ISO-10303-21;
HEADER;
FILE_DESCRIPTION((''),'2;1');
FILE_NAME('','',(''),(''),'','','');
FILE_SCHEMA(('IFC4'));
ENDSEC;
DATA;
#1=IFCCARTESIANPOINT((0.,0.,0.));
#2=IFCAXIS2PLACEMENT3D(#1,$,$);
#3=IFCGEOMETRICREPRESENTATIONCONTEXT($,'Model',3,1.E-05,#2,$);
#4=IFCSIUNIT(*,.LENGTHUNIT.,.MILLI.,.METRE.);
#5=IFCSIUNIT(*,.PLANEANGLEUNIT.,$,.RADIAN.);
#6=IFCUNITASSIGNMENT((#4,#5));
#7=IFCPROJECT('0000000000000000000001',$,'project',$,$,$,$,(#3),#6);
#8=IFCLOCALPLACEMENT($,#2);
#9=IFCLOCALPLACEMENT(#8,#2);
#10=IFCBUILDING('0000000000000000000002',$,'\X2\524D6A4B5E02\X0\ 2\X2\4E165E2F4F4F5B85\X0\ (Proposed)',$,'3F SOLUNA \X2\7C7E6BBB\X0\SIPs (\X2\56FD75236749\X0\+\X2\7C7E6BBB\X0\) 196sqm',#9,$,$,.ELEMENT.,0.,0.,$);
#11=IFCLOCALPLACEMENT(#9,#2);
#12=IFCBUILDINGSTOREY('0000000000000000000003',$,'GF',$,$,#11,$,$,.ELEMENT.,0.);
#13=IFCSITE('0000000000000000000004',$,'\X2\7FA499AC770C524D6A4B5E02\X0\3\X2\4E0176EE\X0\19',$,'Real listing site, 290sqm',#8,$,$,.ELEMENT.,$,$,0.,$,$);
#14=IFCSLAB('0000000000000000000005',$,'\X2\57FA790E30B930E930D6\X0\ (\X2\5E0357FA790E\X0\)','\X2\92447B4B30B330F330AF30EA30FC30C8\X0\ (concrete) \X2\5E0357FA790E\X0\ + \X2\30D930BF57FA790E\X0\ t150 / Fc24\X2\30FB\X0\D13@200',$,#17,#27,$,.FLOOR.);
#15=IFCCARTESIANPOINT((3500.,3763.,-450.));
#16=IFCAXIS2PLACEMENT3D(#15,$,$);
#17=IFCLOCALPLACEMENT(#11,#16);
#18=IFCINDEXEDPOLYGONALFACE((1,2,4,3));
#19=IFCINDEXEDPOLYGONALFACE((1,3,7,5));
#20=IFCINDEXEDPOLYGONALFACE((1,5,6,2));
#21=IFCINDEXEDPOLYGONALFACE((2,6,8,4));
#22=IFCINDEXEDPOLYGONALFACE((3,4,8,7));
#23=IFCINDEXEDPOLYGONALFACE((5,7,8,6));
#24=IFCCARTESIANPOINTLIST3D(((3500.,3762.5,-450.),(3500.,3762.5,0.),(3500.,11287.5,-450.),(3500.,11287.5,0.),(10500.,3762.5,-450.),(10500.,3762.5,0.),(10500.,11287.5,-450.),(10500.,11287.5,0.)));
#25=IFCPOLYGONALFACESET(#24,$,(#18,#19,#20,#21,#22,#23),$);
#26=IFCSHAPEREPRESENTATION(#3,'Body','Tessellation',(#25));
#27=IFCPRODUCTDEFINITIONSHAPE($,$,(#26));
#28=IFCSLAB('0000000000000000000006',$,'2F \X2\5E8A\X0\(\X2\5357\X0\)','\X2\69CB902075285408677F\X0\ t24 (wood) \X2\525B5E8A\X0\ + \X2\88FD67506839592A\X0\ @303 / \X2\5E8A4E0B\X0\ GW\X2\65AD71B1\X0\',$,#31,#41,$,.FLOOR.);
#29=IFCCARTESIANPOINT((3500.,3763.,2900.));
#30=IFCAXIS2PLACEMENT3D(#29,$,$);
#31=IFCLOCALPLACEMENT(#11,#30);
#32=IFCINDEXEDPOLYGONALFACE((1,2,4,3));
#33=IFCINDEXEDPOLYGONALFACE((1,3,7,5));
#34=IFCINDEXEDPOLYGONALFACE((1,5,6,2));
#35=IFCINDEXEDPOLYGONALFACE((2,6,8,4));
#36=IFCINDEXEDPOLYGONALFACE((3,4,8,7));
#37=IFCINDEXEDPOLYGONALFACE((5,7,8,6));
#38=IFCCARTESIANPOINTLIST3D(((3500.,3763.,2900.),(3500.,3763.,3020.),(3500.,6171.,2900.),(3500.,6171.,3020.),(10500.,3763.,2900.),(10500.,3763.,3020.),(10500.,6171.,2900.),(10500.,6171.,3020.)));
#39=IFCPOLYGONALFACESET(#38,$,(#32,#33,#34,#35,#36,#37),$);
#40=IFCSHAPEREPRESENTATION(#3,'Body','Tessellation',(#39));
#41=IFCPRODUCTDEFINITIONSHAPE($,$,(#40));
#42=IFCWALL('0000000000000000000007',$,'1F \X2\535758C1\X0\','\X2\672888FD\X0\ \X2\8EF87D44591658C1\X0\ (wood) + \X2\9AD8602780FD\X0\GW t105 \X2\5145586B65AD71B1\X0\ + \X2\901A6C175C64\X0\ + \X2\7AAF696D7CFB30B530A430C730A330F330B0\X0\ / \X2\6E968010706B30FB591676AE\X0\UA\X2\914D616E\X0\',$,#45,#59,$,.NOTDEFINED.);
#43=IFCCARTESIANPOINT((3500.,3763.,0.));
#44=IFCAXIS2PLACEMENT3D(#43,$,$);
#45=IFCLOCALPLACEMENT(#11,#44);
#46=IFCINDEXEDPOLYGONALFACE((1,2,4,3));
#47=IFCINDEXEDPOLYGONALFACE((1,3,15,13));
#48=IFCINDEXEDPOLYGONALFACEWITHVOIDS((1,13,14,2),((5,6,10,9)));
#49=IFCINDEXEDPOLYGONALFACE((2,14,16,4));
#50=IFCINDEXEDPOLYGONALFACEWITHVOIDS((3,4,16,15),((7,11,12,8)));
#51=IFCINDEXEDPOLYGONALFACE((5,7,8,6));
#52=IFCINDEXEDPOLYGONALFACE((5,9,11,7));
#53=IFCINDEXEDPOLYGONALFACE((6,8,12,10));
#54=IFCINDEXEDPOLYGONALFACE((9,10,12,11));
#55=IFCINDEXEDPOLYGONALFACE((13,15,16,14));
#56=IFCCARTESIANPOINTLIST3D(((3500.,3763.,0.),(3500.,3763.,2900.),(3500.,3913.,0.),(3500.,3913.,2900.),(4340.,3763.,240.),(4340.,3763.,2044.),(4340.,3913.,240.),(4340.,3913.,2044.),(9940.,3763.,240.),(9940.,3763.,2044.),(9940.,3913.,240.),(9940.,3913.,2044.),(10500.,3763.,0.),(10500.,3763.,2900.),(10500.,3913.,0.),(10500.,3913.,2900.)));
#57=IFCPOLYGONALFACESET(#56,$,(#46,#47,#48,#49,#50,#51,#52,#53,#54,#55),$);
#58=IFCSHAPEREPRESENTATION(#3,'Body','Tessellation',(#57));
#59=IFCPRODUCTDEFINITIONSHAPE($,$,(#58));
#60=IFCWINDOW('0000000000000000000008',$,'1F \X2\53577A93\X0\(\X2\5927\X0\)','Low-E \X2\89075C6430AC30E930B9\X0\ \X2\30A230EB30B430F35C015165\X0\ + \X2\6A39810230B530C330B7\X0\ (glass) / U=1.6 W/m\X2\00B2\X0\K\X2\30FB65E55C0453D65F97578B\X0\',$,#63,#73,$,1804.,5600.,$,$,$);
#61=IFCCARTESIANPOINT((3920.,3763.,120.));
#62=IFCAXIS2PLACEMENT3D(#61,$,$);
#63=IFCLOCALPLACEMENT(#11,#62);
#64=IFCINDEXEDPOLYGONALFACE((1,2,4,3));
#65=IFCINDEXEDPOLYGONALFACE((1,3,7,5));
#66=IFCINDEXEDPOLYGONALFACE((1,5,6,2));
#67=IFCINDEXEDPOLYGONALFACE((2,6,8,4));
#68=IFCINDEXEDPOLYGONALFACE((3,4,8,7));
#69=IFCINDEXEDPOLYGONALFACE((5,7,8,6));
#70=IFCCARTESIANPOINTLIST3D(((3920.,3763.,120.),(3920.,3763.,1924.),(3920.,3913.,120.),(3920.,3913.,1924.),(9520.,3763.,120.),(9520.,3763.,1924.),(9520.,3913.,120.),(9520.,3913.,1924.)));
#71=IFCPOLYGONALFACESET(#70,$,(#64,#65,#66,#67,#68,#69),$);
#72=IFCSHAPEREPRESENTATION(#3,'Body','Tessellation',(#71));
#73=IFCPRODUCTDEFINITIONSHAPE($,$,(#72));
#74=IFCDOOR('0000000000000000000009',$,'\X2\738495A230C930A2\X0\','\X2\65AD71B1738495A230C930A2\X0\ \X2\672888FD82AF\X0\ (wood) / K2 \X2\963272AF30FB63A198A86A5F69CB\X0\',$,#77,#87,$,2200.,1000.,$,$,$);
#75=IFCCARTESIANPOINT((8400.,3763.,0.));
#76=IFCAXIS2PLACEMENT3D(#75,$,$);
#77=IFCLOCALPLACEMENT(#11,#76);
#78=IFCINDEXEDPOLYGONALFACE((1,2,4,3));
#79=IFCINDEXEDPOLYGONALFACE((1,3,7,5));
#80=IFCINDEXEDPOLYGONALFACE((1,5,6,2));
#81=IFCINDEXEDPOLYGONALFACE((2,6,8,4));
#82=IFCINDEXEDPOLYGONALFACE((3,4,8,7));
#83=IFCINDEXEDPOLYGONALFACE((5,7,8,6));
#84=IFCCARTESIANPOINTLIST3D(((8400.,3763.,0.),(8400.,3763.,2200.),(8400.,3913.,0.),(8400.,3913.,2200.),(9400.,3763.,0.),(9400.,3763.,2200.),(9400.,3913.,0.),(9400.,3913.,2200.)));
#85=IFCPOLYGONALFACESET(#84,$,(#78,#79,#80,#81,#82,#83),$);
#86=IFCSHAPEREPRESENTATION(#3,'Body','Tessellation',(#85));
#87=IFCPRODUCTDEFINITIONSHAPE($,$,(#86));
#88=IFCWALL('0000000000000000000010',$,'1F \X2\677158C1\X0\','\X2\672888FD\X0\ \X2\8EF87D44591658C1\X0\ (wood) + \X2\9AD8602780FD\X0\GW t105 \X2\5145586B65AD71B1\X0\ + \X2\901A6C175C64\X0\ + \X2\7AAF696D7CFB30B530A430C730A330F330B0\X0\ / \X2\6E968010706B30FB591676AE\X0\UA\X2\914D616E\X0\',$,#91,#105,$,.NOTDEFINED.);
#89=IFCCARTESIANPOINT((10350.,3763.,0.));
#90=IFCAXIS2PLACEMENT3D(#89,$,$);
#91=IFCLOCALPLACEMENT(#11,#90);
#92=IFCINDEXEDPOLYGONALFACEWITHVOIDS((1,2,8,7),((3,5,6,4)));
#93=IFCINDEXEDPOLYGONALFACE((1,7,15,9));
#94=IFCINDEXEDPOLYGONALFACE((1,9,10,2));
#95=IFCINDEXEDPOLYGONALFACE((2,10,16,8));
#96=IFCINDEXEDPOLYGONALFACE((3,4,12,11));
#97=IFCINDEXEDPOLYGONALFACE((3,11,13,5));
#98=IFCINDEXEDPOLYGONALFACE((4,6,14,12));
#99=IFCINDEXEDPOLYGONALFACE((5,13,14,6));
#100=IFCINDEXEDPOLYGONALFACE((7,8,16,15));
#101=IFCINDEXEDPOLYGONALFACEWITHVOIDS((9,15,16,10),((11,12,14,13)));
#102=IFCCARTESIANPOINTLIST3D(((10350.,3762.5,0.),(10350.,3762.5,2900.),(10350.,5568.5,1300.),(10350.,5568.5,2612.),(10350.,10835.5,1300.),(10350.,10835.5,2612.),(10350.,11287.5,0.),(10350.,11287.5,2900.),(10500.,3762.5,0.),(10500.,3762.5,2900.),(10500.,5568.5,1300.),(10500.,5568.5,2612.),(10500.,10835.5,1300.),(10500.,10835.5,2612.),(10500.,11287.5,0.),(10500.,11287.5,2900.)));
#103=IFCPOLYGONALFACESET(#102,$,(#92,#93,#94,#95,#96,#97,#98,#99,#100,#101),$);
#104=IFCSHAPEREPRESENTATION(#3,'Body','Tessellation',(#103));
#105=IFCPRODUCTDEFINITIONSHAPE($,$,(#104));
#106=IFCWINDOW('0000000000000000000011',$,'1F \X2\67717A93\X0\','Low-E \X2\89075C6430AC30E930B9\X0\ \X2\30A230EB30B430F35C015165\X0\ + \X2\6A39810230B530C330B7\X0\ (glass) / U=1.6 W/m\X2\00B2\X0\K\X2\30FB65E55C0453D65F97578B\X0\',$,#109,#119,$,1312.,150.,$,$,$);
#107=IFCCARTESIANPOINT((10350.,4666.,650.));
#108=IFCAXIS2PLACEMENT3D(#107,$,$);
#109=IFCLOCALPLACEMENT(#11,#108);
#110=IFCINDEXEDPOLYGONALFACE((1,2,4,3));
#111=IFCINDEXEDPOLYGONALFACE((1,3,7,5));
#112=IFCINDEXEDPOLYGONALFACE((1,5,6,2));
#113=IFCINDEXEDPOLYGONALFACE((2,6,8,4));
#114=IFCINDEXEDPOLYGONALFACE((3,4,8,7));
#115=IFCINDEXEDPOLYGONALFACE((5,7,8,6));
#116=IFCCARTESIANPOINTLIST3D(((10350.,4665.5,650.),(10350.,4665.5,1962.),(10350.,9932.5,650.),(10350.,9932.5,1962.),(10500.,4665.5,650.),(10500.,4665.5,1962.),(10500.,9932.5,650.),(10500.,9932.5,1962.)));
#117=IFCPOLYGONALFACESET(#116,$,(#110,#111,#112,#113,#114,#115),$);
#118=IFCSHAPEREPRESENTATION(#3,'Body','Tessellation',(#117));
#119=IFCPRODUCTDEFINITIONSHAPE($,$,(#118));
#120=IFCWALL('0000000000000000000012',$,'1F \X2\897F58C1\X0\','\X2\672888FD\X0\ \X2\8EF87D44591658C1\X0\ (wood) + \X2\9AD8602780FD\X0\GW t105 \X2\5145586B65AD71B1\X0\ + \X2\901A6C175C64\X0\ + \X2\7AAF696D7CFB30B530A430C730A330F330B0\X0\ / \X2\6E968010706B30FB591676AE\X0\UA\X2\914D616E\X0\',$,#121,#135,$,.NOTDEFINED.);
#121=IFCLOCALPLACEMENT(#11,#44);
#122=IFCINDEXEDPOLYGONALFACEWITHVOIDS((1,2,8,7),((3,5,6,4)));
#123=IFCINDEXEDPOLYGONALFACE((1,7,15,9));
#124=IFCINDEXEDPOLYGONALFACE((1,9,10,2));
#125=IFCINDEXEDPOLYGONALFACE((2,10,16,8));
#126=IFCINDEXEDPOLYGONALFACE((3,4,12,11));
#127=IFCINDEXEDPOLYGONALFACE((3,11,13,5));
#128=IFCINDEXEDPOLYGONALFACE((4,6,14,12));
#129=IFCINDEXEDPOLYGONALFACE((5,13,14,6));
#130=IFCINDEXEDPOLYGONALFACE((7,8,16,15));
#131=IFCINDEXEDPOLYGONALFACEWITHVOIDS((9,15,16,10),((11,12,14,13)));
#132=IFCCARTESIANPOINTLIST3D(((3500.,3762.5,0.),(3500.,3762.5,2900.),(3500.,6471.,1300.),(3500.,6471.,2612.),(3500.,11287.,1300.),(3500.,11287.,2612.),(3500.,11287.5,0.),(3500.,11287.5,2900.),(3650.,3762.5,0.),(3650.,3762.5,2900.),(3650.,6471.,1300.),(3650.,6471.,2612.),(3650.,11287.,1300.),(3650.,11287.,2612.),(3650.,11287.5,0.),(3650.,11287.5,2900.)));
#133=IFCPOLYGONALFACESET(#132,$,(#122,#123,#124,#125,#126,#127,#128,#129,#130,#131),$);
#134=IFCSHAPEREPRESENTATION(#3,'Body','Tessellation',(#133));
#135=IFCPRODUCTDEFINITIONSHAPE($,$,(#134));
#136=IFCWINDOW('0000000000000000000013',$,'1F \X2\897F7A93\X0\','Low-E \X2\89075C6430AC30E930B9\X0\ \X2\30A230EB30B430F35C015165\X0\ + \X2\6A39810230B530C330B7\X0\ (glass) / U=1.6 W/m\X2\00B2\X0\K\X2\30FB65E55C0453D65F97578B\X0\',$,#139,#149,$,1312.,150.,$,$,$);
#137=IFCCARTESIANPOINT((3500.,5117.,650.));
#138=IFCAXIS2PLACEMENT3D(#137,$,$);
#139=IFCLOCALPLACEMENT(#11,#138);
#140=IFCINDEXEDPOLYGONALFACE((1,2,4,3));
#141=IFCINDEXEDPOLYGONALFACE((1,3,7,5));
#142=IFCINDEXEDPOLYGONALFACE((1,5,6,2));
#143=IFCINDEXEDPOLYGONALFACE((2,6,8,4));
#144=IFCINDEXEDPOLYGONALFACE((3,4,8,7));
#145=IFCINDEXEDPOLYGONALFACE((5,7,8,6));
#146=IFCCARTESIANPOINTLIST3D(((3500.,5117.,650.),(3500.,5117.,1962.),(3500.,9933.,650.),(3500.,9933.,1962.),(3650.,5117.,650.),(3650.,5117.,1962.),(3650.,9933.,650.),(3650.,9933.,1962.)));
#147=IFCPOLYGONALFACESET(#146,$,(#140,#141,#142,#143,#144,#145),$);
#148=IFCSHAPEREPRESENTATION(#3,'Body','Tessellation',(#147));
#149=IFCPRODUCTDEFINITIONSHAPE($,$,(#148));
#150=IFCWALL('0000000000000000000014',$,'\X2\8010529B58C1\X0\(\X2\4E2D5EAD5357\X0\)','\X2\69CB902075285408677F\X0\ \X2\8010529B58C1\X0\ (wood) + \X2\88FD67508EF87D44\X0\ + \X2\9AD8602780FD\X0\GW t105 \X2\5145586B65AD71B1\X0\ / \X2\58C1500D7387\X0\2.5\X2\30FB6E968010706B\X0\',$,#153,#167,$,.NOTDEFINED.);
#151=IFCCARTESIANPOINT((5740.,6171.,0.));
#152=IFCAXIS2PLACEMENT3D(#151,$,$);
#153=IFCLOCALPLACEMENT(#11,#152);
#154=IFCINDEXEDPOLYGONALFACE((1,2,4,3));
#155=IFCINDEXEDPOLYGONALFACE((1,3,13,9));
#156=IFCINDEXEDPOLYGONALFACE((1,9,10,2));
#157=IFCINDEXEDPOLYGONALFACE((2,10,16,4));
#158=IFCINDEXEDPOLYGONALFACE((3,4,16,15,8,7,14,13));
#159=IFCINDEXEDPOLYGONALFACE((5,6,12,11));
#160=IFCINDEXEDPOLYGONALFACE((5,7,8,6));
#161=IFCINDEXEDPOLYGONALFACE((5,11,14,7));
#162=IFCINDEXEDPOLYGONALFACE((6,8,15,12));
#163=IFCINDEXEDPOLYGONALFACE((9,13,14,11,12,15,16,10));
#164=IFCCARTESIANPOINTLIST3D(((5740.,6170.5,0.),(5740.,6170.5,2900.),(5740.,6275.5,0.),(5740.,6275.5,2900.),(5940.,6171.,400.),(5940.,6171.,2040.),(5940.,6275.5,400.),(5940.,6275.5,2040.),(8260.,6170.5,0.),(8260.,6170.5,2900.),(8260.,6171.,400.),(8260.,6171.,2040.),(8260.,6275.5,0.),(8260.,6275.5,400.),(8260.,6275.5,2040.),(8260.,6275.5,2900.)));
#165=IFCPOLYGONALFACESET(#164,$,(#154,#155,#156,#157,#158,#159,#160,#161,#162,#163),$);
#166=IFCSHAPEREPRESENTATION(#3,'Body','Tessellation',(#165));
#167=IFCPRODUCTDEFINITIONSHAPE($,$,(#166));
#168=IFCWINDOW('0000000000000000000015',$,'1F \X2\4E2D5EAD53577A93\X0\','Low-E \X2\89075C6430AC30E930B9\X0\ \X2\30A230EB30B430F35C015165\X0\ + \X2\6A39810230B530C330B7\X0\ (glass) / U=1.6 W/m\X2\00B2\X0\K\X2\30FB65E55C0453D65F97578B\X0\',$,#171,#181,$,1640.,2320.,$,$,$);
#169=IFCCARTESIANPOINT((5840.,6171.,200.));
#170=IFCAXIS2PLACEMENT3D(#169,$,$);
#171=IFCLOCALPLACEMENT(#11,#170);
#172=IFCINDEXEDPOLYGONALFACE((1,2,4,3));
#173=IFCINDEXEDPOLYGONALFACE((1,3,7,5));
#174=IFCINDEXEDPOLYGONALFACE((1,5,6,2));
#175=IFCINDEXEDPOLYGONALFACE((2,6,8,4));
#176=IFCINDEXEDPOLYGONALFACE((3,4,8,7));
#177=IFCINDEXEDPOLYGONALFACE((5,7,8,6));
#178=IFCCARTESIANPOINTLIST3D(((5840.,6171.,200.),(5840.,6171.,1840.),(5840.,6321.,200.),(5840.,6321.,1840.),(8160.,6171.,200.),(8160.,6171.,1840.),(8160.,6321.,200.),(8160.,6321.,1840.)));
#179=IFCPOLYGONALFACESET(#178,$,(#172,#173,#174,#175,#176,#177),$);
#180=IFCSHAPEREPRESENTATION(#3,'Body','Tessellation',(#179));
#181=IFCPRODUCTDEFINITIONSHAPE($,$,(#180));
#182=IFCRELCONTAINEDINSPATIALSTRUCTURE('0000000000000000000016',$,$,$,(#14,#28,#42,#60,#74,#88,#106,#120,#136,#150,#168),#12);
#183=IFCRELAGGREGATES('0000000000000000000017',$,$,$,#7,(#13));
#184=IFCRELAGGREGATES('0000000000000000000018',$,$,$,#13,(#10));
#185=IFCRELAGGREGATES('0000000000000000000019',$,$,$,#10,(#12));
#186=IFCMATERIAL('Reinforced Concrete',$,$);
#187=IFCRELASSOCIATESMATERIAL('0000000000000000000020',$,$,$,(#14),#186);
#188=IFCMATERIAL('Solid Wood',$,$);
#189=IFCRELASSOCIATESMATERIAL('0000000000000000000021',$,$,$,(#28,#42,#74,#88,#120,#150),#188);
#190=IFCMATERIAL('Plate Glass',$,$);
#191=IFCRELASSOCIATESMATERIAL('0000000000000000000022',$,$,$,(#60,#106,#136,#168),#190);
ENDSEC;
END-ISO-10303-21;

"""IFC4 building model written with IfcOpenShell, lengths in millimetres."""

from ifc_helpers import new_model, si_unit, frame, frame_2d, origin, place, context, project, spatial, rectangle, extrude, material, element, fill, save


model = new_model("IFC4")

# Units and contexts
model_context = context("Model", 3, precision=1e-05, world=origin())
ifc_project = project(units=[si_unit("LENGTHUNIT", "METRE", prefix="MILLI"), si_unit("PLANEANGLEUNIT", "RADIAN")], contexts=[model_context])

# Site, building, storey
site_placement = place(None, origin())
site = spatial("IfcSite", under=ifc_project, at=site_placement, Name="群馬県前橋市3丁目19", ObjectType="Real listing site, 290sqm", CompositionType="ELEMENT", RefElevation=0.0)
building_placement = place(site_placement, origin())
building = spatial("IfcBuilding", under=site, at=building_placement, Name="前橋市 2世帯住宅 (Proposed)", ObjectType="3F SOLUNA 籾殻SIPs (国産杉+籾殻) 196sqm", CompositionType="ELEMENT", ElevationOfRefHeight=0.0, ElevationOfTerrain=0.0)
storey_placement = place(building_placement, origin())
storey = spatial("IfcBuildingStorey", under=building, at=storey_placement, Name="GF", CompositionType="ELEMENT", Elevation=0.0)

# Slabs
ifc_material_1 = material(Name="Reinforced Concrete")
slab_1_placement = place(storey_placement, frame((3500.0, 3763.0, -450.0)))
element("IfcSlab", 1, at=slab_1_placement, inside=storey, material=ifc_material_1, Name="基礎スラブ (布基礎)", Description="鉄筋コンクリート (concrete) 布基礎 + ベタ基礎 t150 / Fc24・D13@200", PredefinedType="FLOOR", context=model_context, shape_type="SweptSolid", body=[
    extrude(rectangle(XDim=7000.0, YDim=7525.0, at=frame_2d((3500.0, 3762.0))), frame((3500.0, 3763.0, -450.0)), (0.0, 0.0, 1.0), 450.0),
])
ifc_material_2 = material(Name="Solid Wood")
slab_2_placement = place(storey_placement, frame((3500.0, 3763.0, 2900.0)))
element("IfcSlab", 2, at=slab_2_placement, inside=storey, material=ifc_material_2, Name="2F 床(南)", Description="構造用合板 t24 (wood) 剛床 + 製材根太 @303 / 床下 GW断熱", PredefinedType="FLOOR", context=model_context, shape_type="SweptSolid", body=[
    extrude(rectangle(XDim=7000.0, YDim=2408.0, at=frame_2d((3500.0, 1204.0))), frame((3500.0, 3763.0, 2900.0)), (0.0, 0.0, 1.0), 120.0),
])

# Wall, openings, window, door
wall_1_placement = place(storey_placement, frame((3500.0, 3763.0, 0.0)))
wall_1 = element("IfcWall", 3, at=wall_1_placement, inside=storey, material=ifc_material_2, Name="1F 南壁", Description="木製 軸組外壁 (wood) + 高性能GW t105 充填断熱 + 通気層 + 窯業系サイディング / 準耐火・外皮UA配慮", PredefinedType="NOTDEFINED", context=model_context, shape_type="SweptSolid", body=[
    extrude(rectangle(XDim=7000.0, YDim=150.0, at=frame_2d((3500.0, 75.0))), frame((3500.0, 3763.0, 0.0)), (0.0, 0.0, 1.0), 2900.0),
])
opening_1_placement = place(storey_placement, frame((3920.0, 3763.0, 120.0)))
opening_1 = element("IfcOpeningElement", 4, at=opening_1_placement, cuts=wall_1, PredefinedType="NOTDEFINED", context=model_context, shape_type="SweptSolid", body=[
    extrude(rectangle(XDim=5600.0, YDim=150.0, at=frame_2d((2800.0, 75.0))), frame((3920.0, 3763.0, 120.0)), (0.0, 0.0, 1.0), 1804.0),
])
opening_2_placement = place(storey_placement, frame((8400.0, 3763.0, 0.0)))
opening_2 = element("IfcOpeningElement", 5, at=opening_2_placement, cuts=wall_1, PredefinedType="NOTDEFINED", context=model_context, shape_type="SweptSolid", body=[
    extrude(rectangle(XDim=1000.0, YDim=150.0, at=frame_2d((500.0, 75.0))), frame((8400.0, 3763.0, 0.0)), (0.0, 0.0, 1.0), 2200.0),
])
ifc_material_3 = material(Name="Plate Glass")
window_1_placement = place(storey_placement, frame((3920.0, 3763.0, 120.0)))
window_1 = element("IfcWindow", 6, at=window_1_placement, inside=storey, material=ifc_material_3, Name="1F 南窓(大)", Description="Low-E 複層ガラス アルゴン封入 + 樹脂サッシ (glass) / U=1.6 W/m²K・日射取得型", OverallHeight=1804.0, OverallWidth=5600.0, context=model_context, shape_type="SweptSolid", body=[
    extrude(rectangle(XDim=5600.0, YDim=150.0, at=frame_2d((2800.0, 75.0))), frame((3920.0, 3763.0, 120.0)), (0.0, 0.0, 1.0), 1804.0),
])
fill(opening_1, window_1)
door_placement = place(storey_placement, frame((8400.0, 3763.0, 0.0)))
door = element("IfcDoor", 7, at=door_placement, inside=storey, material=ifc_material_2, Name="玄関ドア", Description="断熱玄関ドア 木製芯 (wood) / K2 防犯・採風機構", OverallHeight=2200.0, OverallWidth=1000.0, context=model_context, shape_type="SweptSolid", body=[
    extrude(rectangle(XDim=1000.0, YDim=150.0, at=frame_2d((500.0, 75.0))), frame((8400.0, 3763.0, 0.0)), (0.0, 0.0, 1.0), 2200.0),
])
fill(opening_2, door)

# Walls, openings, windows
wall_2_placement = place(storey_placement, frame((10350.0, 3763.0, 0.0)))
wall_2 = element("IfcWall", 8, at=wall_2_placement, inside=storey, material=ifc_material_2, Name="1F 東壁", Description="木製 軸組外壁 (wood) + 高性能GW t105 充填断熱 + 通気層 + 窯業系サイディング / 準耐火・外皮UA配慮", PredefinedType="NOTDEFINED", context=model_context, shape_type="SweptSolid", body=[
    extrude(rectangle(XDim=150.0, YDim=7525.0, at=frame_2d((75.0, 3762.0))), frame((10350.0, 3763.0, 0.0)), (0.0, 0.0, 1.0), 2900.0),
])
opening_3_placement = place(storey_placement, frame((10350.0, 4666.0, 650.0)))
opening_3 = element("IfcOpeningElement", 9, at=opening_3_placement, cuts=wall_2, PredefinedType="NOTDEFINED", context=model_context, shape_type="SweptSolid", body=[
    extrude(rectangle(XDim=150.0, YDim=5267.0, at=frame_2d((75.0, 2633.0))), frame((10350.0, 4666.0, 650.0)), (0.0, 0.0, 1.0), 1312.0),
])
window_2_placement = place(storey_placement, frame((10350.0, 4666.0, 650.0)))
window_2 = element("IfcWindow", 10, at=window_2_placement, inside=storey, material=ifc_material_3, Name="1F 東窓", Description="Low-E 複層ガラス アルゴン封入 + 樹脂サッシ (glass) / U=1.6 W/m²K・日射取得型", OverallHeight=1312.0, OverallWidth=150.0, context=model_context, shape_type="SweptSolid", body=[
    extrude(rectangle(XDim=150.0, YDim=5267.0, at=frame_2d((75.0, 2633.0))), frame((10350.0, 4666.0, 650.0)), (0.0, 0.0, 1.0), 1312.0),
])
fill(opening_3, window_2)
wall_3_placement = place(storey_placement, frame((3500.0, 3763.0, 0.0)))
wall_3 = element("IfcWall", 11, at=wall_3_placement, inside=storey, material=ifc_material_2, Name="1F 西壁", Description="木製 軸組外壁 (wood) + 高性能GW t105 充填断熱 + 通気層 + 窯業系サイディング / 準耐火・外皮UA配慮", PredefinedType="NOTDEFINED", context=model_context, shape_type="SweptSolid", body=[
    extrude(rectangle(XDim=150.0, YDim=7525.0, at=frame_2d((75.0, 3762.0))), frame((3500.0, 3763.0, 0.0)), (0.0, 0.0, 1.0), 2900.0),
])
opening_4_placement = place(storey_placement, frame((3500.0, 5117.0, 650.0)))
opening_4 = element("IfcOpeningElement", 12, at=opening_4_placement, cuts=wall_3, PredefinedType="NOTDEFINED", context=model_context, shape_type="SweptSolid", body=[
    extrude(rectangle(XDim=150.0, YDim=4816.0, at=frame_2d((75.0, 2408.0))), frame((3500.0, 5117.0, 650.0)), (0.0, 0.0, 1.0), 1312.0),
])
window_3_placement = place(storey_placement, frame((3500.0, 5117.0, 650.0)))
window_3 = element("IfcWindow", 13, at=window_3_placement, inside=storey, material=ifc_material_3, Name="1F 西窓", Description="Low-E 複層ガラス アルゴン封入 + 樹脂サッシ (glass) / U=1.6 W/m²K・日射取得型", OverallHeight=1312.0, OverallWidth=150.0, context=model_context, shape_type="SweptSolid", body=[
    extrude(rectangle(XDim=150.0, YDim=4816.0, at=frame_2d((75.0, 2408.0))), frame((3500.0, 5117.0, 650.0)), (0.0, 0.0, 1.0), 1312.0),
])
fill(opening_4, window_3)
wall_4_placement = place(storey_placement, frame((5740.0, 6171.0, 0.0)))
wall_4 = element("IfcWall", 14, at=wall_4_placement, inside=storey, material=ifc_material_2, Name="耐力壁(中庭南)", Description="構造用合板 耐力壁 (wood) + 製材軸組 + 高性能GW t105 充填断熱 / 壁倍率2.5・準耐火", PredefinedType="NOTDEFINED", context=model_context, shape_type="SweptSolid", body=[
    extrude(rectangle(XDim=2520.0, YDim=105.0, at=frame_2d((1260.0, 52.0))), frame((5740.0, 6171.0, 0.0)), (0.0, 0.0, 1.0), 2900.0),
])
opening_5_placement = place(storey_placement, frame((5840.0, 6171.0, 200.0)))
opening_5 = element("IfcOpeningElement", 15, at=opening_5_placement, cuts=wall_4, PredefinedType="NOTDEFINED", context=model_context, shape_type="SweptSolid", body=[
    extrude(rectangle(XDim=2320.0, YDim=150.0, at=frame_2d((1160.0, 75.0))), frame((5840.0, 6171.0, 200.0)), (0.0, 0.0, 1.0), 1640.0),
])
window_4_placement = place(storey_placement, frame((5840.0, 6171.0, 200.0)))
window_4 = element("IfcWindow", 16, at=window_4_placement, inside=storey, material=ifc_material_3, Name="1F 中庭南窓", Description="Low-E 複層ガラス アルゴン封入 + 樹脂サッシ (glass) / U=1.6 W/m²K・日射取得型", OverallHeight=1640.0, OverallWidth=2320.0, context=model_context, shape_type="SweptSolid", body=[
    extrude(rectangle(XDim=2320.0, YDim=150.0, at=frame_2d((1160.0, 75.0))), frame((5840.0, 6171.0, 200.0)), (0.0, 0.0, 1.0), 1640.0),
])
fill(opening_5, window_4)

save(model, "model.ifc")
